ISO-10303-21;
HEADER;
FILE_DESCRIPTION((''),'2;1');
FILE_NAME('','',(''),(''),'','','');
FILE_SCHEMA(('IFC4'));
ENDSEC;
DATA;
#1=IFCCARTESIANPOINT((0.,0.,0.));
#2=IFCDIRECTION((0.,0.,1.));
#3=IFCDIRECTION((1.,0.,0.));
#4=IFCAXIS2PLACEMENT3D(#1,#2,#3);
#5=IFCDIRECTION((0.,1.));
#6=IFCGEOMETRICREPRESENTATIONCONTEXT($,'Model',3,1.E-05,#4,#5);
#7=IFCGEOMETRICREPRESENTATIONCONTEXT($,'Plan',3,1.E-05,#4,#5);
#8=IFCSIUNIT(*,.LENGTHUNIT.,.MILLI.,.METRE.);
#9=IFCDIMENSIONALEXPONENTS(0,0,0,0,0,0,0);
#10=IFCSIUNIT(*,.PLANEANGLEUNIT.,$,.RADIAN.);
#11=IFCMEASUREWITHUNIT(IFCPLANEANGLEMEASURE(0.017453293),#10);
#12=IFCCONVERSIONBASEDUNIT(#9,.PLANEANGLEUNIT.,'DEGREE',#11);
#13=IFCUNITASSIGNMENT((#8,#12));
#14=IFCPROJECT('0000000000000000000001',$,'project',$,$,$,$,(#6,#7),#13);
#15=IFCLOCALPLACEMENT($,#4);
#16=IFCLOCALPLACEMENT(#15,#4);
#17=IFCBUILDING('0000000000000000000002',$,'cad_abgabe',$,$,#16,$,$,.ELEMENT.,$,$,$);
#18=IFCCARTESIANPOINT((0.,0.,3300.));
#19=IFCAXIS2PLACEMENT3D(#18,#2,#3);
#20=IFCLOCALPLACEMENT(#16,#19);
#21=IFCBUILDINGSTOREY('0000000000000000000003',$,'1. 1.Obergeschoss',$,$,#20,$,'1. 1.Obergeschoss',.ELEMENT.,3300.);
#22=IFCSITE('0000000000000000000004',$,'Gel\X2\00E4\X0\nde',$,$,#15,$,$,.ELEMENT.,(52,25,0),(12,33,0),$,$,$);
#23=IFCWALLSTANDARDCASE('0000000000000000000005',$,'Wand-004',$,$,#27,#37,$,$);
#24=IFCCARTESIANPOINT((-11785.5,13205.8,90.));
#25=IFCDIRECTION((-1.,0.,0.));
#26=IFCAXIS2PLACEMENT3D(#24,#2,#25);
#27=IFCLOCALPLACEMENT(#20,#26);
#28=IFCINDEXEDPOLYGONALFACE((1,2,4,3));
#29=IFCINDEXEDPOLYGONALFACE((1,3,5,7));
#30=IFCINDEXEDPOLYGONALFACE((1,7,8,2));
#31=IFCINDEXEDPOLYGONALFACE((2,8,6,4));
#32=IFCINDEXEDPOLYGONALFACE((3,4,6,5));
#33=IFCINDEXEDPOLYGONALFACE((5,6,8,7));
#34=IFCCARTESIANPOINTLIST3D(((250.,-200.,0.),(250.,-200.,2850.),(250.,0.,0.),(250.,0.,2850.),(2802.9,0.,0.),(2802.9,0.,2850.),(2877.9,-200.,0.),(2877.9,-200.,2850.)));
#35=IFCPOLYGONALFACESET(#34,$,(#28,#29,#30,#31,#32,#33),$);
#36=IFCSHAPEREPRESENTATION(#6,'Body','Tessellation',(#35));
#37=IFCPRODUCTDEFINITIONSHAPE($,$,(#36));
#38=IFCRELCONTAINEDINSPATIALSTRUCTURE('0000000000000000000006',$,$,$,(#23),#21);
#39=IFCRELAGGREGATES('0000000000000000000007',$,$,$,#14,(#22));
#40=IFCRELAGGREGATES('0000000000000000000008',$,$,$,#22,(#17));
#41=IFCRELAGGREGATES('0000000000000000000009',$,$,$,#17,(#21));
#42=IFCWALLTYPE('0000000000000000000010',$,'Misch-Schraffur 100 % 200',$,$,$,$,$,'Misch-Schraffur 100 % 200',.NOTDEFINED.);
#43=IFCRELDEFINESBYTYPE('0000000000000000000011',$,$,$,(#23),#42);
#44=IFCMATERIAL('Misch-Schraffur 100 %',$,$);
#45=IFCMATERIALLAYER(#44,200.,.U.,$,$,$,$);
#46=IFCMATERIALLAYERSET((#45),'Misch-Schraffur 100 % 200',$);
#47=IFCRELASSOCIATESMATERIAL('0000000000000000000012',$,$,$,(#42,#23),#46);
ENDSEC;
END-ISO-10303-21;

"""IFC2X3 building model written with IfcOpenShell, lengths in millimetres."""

from ifc_helpers import new_model, entity, si_unit, converted_unit, direction, frame, origin_with_axes, place, context, project, spatial, polyline, outline, extrude, material, layer, layer_set, layer_usage, type_object, element, save


model = new_model("IFC2X3")

# Units and contexts
model_context = context("Model", 3, precision=1e-05, world=origin_with_axes(), true_north=direction((0.0, 1.0)))
plan_context = context("Plan", 3, precision=1e-05, world=origin_with_axes(), true_north=direction((0.0, 1.0)))
ifc_project = project(units=[si_unit("LENGTHUNIT", "METRE", prefix="MILLI"), converted_unit("PLANEANGLEUNIT", "DEGREE", entity("IfcPlaneAngleMeasure", 0.017453293), si_unit("PLANEANGLEUNIT", "RADIAN"), dimensions=[0, 0, 0, 0, 0, 0, 0])], contexts=[model_context, plan_context])

# Site, building, storey
site_placement = place(None, origin_with_axes())
site = spatial("IfcSite", under=ifc_project, at=site_placement, Name="Gelände", CompositionType="ELEMENT", RefLatitude=(52, 25, 0), RefLongitude=(12, 33, 0))
building_placement = place(site_placement, origin_with_axes())
building = spatial("IfcBuilding", under=site, at=building_placement, Name="cad_abgabe", CompositionType="ELEMENT")
storey_placement = place(building_placement, frame((0.0, 0.0, 3300.0), z_axis=(0.0, 0.0, 1.0), x_axis=(1.0, 0.0, 0.0)))
storey = spatial("IfcBuildingStorey", under=building, at=storey_placement, Name="1. 1.Obergeschoss", LongName="1. 1.Obergeschoss", CompositionType="ELEMENT", Elevation=3300.0)

# Shared definitions
ifc_material = material(Name="Misch-Schraffur 100 %")

# Wall
ifc_layer_1 = layer(ifc_material, 200.0, ventilated="UNKNOWN")
ifc_layer_set_1 = layer_set([ifc_layer_1], Name="Misch-Schraffur 100 % 200")
ifc_layer_usage_1 = layer_usage(ifc_layer_set_1, "AXIS2", "NEGATIVE", 0.0)
wall_type_1 = type_object("IfcWallType", Name="Misch-Schraffur 100 % 200", ElementType="Misch-Schraffur 100 % 200", PredefinedType="NOTDEFINED", material=ifc_layer_set_1)
wall_1_placement = place(storey_placement, frame((-11785.5, 13205.8, 90.0), z_axis=(0.0, 0.0, 1.0), x_axis=(-1.0, 0.0, 0.0)))
element("IfcWallStandardCase", 1, at=wall_1_placement, inside=storey, type_object=wall_type_1, material=ifc_layer_usage_1, Name="Wand-004", context=model_context, shape_type="SweptSolid", body=[
    extrude(outline(polyline([(250.0, -200.0), (2877.9, -200.0), (2802.9, 0.0), (250.0, 0.0), (250.0, -200.0)])), origin_with_axes(), (0.0, 0.0, 1.0), 2850.0),
])

save(model, "model.ifc")
